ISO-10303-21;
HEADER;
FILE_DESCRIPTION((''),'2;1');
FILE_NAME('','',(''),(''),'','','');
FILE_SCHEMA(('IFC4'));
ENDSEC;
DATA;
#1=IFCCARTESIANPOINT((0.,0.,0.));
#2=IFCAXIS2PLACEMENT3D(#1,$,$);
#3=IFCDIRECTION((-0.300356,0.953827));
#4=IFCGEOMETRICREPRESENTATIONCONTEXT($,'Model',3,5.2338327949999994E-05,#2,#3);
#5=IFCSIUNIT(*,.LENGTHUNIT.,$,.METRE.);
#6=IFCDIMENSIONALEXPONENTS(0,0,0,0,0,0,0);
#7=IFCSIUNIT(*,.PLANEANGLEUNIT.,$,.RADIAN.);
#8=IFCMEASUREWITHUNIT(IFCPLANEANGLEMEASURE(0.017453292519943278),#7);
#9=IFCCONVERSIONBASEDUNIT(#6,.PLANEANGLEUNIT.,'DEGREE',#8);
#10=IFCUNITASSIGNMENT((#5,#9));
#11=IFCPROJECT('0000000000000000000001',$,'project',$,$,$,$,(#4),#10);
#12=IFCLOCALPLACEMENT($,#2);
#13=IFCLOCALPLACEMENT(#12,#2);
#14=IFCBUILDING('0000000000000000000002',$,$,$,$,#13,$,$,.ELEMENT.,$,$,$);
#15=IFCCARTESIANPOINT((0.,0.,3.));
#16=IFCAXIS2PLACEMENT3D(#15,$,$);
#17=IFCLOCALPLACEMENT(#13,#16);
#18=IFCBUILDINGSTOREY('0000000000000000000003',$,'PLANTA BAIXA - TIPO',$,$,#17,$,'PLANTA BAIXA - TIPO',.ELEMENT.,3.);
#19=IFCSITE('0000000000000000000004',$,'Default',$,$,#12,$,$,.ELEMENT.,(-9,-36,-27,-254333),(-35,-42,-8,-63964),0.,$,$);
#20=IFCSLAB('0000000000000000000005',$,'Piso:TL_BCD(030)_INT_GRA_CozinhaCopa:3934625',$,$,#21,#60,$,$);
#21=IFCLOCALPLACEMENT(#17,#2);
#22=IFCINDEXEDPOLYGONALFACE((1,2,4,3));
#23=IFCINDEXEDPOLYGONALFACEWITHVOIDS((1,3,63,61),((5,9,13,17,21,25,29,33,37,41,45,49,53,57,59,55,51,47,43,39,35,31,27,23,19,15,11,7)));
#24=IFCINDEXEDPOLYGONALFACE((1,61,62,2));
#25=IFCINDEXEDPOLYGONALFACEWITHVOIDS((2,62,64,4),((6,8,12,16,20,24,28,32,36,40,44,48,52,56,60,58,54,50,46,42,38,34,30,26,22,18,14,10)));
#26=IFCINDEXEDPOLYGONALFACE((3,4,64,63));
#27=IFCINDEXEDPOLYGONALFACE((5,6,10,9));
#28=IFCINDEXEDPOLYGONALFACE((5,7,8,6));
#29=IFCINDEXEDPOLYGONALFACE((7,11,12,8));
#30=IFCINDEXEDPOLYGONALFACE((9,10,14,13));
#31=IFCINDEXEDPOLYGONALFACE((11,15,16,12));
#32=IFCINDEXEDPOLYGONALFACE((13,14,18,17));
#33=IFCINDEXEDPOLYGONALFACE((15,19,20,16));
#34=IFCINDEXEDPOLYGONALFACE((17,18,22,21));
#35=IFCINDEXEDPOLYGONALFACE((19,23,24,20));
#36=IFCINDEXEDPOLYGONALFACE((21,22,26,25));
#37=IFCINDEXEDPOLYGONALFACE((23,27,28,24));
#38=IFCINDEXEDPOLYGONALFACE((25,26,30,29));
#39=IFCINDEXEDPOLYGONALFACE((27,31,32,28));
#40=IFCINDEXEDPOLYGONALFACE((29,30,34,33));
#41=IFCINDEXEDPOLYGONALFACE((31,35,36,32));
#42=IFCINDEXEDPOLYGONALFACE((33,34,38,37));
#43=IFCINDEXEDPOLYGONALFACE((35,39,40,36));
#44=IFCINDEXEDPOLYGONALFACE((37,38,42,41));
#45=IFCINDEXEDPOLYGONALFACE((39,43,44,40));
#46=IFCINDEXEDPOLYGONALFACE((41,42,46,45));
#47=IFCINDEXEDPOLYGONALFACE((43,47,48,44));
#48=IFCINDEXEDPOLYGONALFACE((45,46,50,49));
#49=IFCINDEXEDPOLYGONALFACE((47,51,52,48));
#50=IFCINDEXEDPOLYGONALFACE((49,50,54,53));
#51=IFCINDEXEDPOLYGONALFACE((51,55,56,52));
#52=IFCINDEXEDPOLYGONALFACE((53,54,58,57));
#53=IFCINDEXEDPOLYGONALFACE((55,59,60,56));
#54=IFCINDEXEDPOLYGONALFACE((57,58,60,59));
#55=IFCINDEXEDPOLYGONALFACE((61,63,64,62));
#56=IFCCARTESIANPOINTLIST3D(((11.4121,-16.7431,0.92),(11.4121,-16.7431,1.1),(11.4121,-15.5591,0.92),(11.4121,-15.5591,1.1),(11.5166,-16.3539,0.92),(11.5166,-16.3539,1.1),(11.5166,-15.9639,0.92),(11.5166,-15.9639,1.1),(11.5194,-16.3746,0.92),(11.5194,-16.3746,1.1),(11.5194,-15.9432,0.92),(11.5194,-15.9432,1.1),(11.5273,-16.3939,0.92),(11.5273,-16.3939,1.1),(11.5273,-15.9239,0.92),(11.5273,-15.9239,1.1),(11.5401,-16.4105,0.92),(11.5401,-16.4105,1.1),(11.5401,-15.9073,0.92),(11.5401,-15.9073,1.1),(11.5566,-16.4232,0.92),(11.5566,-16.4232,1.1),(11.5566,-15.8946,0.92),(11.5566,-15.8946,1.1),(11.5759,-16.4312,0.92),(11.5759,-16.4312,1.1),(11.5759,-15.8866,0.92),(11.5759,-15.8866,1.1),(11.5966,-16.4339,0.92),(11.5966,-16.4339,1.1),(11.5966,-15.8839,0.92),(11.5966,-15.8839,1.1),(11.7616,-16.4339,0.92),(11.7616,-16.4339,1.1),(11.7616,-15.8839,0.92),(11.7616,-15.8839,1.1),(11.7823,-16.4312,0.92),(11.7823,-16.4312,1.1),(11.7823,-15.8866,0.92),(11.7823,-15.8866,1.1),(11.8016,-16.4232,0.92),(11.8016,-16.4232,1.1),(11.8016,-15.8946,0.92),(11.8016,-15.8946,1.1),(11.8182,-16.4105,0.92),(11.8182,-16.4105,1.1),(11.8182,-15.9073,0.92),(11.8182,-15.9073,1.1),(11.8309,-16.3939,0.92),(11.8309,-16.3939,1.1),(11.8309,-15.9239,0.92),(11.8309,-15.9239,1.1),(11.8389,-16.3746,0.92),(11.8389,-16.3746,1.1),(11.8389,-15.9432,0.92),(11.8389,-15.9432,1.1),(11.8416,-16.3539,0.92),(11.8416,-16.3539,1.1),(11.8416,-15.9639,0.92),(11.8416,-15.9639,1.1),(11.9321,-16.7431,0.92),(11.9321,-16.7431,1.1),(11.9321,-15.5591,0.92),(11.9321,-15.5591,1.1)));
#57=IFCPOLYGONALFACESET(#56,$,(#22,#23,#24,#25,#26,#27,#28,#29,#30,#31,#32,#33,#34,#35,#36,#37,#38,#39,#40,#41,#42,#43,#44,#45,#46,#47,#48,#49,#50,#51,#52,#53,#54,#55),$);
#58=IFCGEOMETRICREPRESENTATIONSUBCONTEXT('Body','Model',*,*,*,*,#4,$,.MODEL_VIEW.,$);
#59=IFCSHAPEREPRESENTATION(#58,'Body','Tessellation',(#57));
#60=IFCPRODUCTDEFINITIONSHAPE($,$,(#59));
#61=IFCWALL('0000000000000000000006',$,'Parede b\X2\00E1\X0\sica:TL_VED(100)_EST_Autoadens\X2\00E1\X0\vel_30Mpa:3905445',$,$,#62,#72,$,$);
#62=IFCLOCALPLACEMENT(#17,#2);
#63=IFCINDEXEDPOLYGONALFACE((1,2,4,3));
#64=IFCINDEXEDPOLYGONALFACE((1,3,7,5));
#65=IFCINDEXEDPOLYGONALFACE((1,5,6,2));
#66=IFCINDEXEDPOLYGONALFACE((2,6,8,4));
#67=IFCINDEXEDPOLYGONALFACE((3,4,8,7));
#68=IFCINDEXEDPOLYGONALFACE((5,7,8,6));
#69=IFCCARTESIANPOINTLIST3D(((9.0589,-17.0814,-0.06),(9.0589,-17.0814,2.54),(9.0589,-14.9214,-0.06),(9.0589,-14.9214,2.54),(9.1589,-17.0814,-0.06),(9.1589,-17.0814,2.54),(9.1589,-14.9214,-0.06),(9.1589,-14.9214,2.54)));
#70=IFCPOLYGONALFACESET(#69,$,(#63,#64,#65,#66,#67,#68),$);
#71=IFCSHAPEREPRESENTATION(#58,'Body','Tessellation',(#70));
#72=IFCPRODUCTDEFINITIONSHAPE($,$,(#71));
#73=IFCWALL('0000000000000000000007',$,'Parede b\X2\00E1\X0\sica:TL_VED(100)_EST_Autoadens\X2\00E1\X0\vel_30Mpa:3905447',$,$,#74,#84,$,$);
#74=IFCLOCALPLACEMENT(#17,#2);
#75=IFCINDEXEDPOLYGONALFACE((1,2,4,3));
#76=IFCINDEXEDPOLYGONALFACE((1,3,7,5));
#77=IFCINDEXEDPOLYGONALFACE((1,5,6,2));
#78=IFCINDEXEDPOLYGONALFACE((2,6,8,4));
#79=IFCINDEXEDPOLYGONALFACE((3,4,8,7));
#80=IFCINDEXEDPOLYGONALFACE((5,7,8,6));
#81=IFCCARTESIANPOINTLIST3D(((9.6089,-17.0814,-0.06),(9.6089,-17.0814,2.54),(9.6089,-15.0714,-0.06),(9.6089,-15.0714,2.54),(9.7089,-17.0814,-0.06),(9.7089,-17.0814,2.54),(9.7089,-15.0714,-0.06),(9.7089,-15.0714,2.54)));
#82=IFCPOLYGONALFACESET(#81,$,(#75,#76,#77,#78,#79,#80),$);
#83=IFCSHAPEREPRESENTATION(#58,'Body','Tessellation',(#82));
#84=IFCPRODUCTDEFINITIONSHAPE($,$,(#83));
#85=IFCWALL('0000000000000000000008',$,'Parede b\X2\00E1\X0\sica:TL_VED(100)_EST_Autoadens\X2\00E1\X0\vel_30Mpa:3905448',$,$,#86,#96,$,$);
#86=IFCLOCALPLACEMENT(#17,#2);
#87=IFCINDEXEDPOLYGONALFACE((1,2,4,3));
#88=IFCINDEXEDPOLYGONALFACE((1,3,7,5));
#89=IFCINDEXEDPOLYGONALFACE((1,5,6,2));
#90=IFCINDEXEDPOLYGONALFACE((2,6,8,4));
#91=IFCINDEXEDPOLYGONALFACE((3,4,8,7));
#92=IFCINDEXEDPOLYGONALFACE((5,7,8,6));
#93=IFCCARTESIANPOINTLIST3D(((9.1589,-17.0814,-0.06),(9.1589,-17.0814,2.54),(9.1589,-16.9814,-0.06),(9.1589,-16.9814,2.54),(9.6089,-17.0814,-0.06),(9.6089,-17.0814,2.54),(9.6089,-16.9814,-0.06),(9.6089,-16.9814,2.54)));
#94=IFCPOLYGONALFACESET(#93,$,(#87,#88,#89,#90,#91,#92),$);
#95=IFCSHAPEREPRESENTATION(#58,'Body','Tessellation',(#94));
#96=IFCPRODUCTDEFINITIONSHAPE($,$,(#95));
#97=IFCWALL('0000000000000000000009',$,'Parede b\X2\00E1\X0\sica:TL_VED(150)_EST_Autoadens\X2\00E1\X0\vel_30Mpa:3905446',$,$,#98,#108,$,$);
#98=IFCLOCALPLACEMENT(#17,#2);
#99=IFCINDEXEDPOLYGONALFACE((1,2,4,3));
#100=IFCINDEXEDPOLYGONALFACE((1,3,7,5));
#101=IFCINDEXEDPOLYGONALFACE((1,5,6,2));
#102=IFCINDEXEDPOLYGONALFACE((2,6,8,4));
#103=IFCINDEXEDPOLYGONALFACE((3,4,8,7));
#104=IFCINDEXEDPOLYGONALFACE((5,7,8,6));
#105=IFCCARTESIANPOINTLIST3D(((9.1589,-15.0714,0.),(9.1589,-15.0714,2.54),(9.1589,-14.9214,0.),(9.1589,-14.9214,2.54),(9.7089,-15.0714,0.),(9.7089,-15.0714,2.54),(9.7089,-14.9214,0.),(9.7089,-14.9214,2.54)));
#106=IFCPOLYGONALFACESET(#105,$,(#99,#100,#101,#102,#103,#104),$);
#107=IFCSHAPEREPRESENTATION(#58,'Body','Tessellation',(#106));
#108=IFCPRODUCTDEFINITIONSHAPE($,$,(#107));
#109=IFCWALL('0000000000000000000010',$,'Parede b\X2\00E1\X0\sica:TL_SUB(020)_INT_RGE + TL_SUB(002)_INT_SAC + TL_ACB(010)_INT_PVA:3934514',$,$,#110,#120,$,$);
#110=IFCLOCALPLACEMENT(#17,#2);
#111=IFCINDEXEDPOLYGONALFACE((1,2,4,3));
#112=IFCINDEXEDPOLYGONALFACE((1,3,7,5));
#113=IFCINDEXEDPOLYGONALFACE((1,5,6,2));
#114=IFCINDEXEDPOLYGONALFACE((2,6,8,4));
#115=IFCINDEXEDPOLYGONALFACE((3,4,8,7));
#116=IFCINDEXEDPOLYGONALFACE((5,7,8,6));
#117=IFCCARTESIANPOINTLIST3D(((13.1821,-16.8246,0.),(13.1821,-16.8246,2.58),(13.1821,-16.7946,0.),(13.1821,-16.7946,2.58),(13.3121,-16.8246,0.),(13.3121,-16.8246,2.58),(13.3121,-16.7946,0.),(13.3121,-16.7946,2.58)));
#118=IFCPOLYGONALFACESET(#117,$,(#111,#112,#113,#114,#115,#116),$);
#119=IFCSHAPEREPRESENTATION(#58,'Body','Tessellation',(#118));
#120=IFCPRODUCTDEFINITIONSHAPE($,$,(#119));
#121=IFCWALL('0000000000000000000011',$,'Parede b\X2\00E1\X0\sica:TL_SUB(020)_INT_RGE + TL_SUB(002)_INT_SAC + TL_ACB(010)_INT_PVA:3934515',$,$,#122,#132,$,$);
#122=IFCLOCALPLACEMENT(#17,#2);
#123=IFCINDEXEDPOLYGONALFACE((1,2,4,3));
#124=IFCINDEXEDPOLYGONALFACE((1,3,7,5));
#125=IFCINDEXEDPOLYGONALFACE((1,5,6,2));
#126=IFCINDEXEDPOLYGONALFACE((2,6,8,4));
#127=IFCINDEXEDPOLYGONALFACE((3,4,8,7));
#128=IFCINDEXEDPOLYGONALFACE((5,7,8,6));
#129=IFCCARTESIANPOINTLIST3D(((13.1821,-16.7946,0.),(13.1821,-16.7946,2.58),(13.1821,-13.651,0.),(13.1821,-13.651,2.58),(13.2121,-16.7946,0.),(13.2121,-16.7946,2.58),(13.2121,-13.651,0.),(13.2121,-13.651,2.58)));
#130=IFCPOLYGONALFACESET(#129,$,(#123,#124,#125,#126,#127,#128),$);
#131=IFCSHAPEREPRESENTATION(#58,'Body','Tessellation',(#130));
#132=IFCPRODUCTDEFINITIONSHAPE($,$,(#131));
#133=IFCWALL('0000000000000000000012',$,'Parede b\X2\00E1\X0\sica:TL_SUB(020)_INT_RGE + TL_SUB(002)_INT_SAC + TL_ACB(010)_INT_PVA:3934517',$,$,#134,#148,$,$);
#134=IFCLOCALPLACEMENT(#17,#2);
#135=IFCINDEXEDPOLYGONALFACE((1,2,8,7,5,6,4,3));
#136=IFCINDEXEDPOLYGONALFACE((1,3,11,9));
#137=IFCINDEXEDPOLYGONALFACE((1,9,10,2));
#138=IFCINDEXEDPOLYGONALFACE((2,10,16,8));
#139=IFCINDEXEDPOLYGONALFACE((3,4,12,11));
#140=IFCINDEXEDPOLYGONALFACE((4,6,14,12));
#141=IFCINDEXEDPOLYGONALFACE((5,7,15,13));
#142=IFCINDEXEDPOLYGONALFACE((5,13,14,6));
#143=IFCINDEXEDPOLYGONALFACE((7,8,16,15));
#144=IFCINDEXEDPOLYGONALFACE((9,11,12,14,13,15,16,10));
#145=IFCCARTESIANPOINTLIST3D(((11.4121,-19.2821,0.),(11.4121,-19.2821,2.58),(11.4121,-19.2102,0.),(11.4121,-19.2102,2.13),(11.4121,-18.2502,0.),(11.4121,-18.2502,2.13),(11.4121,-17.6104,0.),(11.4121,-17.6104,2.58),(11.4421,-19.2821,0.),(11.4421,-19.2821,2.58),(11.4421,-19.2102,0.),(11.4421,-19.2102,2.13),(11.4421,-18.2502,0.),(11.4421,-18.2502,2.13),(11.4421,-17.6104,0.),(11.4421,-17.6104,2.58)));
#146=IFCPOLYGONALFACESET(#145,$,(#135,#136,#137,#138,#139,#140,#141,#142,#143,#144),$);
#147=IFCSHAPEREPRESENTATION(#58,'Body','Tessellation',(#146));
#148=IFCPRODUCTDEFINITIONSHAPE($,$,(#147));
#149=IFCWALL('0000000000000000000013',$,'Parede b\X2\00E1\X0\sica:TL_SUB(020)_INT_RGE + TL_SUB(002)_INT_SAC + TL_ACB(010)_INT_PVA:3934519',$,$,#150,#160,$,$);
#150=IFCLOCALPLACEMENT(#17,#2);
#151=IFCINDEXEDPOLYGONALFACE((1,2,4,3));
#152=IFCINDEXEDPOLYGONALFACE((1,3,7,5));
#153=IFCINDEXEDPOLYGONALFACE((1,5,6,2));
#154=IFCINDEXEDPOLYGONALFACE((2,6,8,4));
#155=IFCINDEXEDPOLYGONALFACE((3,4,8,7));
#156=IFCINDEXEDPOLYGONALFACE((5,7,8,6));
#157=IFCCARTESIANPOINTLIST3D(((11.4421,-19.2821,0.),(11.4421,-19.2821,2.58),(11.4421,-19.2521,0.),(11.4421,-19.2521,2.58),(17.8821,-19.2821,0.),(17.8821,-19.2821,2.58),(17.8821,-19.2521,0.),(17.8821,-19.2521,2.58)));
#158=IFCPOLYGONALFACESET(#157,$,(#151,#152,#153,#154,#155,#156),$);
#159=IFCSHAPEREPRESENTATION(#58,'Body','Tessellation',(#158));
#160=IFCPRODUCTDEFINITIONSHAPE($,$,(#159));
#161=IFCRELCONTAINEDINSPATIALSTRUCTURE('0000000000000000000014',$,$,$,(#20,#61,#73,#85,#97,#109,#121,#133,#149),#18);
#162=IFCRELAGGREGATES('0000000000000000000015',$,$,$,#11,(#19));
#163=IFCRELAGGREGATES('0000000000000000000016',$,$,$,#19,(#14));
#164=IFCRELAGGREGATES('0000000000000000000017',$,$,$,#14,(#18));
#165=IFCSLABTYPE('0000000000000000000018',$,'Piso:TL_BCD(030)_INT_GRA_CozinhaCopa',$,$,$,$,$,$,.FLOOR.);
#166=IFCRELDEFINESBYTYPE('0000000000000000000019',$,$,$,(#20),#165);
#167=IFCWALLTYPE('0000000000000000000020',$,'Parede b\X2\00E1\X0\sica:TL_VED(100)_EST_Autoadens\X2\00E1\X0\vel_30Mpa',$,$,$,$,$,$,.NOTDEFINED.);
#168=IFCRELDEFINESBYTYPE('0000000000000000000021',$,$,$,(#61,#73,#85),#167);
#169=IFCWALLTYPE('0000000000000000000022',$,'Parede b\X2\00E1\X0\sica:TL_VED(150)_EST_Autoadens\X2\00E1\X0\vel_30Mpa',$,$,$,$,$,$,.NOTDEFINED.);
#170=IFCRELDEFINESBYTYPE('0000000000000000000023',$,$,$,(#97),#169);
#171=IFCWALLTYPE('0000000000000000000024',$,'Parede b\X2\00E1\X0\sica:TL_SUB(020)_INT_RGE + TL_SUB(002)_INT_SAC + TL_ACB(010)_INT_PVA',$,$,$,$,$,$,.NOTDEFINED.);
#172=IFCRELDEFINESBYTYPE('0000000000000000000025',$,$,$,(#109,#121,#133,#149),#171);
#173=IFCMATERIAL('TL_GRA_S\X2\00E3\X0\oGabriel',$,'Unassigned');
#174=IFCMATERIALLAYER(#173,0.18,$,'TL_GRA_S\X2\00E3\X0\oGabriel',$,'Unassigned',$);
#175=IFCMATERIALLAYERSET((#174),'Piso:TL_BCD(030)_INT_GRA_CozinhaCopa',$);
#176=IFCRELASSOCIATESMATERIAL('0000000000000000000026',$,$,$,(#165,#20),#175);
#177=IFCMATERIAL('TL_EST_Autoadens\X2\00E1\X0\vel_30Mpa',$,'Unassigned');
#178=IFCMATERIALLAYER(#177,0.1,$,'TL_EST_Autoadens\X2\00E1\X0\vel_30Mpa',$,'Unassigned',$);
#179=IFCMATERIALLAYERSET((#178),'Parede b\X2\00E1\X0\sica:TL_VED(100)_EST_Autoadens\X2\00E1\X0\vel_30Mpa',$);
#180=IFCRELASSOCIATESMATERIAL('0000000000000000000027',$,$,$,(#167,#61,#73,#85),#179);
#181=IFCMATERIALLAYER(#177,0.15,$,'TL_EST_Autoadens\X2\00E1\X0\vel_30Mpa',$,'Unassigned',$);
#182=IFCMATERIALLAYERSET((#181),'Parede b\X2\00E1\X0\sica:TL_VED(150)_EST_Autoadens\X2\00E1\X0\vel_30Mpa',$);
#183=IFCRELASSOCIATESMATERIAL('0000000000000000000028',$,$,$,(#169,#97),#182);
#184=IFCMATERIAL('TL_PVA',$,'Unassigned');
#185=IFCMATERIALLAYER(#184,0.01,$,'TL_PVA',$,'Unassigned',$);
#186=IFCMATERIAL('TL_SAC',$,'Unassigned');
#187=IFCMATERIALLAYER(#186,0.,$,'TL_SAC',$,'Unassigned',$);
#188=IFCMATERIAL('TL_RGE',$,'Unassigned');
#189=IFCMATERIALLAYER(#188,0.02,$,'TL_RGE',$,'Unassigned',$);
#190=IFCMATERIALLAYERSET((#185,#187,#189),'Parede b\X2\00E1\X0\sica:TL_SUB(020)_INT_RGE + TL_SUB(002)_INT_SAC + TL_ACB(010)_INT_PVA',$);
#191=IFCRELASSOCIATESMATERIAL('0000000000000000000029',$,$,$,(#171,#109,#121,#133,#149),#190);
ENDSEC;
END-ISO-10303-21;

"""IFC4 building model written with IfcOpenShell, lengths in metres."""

from ifc_helpers import new_model, entity, si_unit, converted_unit, direction, frame, frame_2d, origin, place, context, subcontext, project, spatial, polyline, circle_curve, parameter, trimmed, segment, composite_curve, rectangle, outline, extrude, material, layer, layer_set, layer_usage, type_object, element, save


model = new_model("IFC4")

# Units and contexts
model_context = context("Model", 3, precision=5.2338327949999994e-05, world=origin(), true_north=direction((-0.300356, 0.953827)))
body_context = subcontext(model_context, "Body", "Model", "MODEL_VIEW")
ifc_project = project(units=[si_unit("LENGTHUNIT", "METRE"), converted_unit("PLANEANGLEUNIT", "DEGREE", entity("IfcPlaneAngleMeasure", 0.017453292519943278), si_unit("PLANEANGLEUNIT", "RADIAN"), dimensions=[0, 0, 0, 0, 0, 0, 0])], contexts=[model_context])

# Site, building, storey
site_placement = place(None, origin())
site = spatial("IfcSite", under=ifc_project, at=site_placement, Name="Default", CompositionType="ELEMENT", RefLatitude=(-9, -36, -27, -254333), RefLongitude=(-35, -42, -8, -63964), RefElevation=0.0)
building_placement = place(site_placement, origin())
building = spatial("IfcBuilding", under=site, at=building_placement, CompositionType="ELEMENT")
storey_placement = place(building_placement, frame((0.0, 0.0, 3.0)))
storey = spatial("IfcBuildingStorey", under=building, at=storey_placement, Name="PLANTA BAIXA - TIPO", LongName="PLANTA BAIXA - TIPO", CompositionType="ELEMENT", Elevation=3.0)

# Slab, opening
ifc_material_1 = material(Name="TL_GRA_SãoGabriel", Category="Unassigned")
ifc_layer_1 = layer(ifc_material_1, 0.18, Name="TL_GRA_SãoGabriel", Category="Unassigned")
ifc_layer_set_1 = layer_set([ifc_layer_1], Name="Piso:TL_BCD(030)_INT_GRA_CozinhaCopa")
ifc_layer_usage_1 = layer_usage(ifc_layer_set_1, "AXIS3", "POSITIVE", 0.0)
slab_type_1 = type_object("IfcSlabType", Name="Piso:TL_BCD(030)_INT_GRA_CozinhaCopa", PredefinedType="FLOOR", material=ifc_layer_set_1)
slab_1_placement = place(storey_placement, frame((11.4121, -16.7431, 0.92)))
slab_1 = element("IfcSlab", 1, at=slab_1_placement, inside=storey, type_object=slab_type_1, material=ifc_layer_usage_1, Name="Piso:TL_BCD(030)_INT_GRA_CozinhaCopa:3934625", context=body_context, shape_type="SweptSolid", body=[
    extrude(rectangle(XDim=0.52, YDim=1.184, at=frame_2d((0.0, 0.0), x_axis=(-1.0, 0.0))), frame((0.26, 0.592, 0.18), z_axis=(0.0, 0.0, -1.0), x_axis=(-1.0, 0.0, 0.0)), (0.0, 0.0, 1.0), 0.18),
])
opening_1_placement = place(slab_1_placement, frame((-11.4121, 16.7431, 0.18)))
element("IfcOpeningElement", 2, at=opening_1_placement, cuts=slab_1, PredefinedType="OPENING", context=body_context, shape_type="SweptSolid", body=[
    extrude(outline(composite_curve([segment(trimmed(circle_curve(frame_2d((0.195, -0.0825), x_axis=(1.0, 0.0)), 0.08), [parameter(270.0)], [parameter(0.0)], True, "PARAMETER"), True, "CONTINUOUS"), segment(polyline([(0.275, -0.0825), (0.275, 0.0825)]), True, "CONTINUOUS"), segment(trimmed(circle_curve(frame_2d((0.195, 0.0825), x_axis=(1.0, 0.0)), 0.08), [parameter(0.0)], [parameter(90.0)], True, "PARAMETER"), True, "CONTINUOUS"), segment(polyline([(0.195, 0.1625), (-0.195, 0.1625)]), True, "CONTINUOUS"), segment(trimmed(circle_curve(frame_2d((-0.195, 0.0825), x_axis=(1.0, 0.0)), 0.08), [parameter(90.0)], [parameter(180.0)], True, "PARAMETER"), True, "CONTINUOUS"), segment(polyline([(-0.275, 0.0825), (-0.275, -0.0825)]), True, "CONTINUOUS"), segment(trimmed(circle_curve(frame_2d((-0.195, -0.0825), x_axis=(1.0, 0.0)), 0.08), [parameter(180.0)], [parameter(270.0)], True, "PARAMETER"), True, "CONTINUOUS"), segment(polyline([(-0.195, -0.1625), (0.195, -0.1625)]), True, "CONTINUOUS")], self_intersect=False)), frame((11.6791, -16.1589, -0.21), z_axis=(0.0, 0.0, 1.0), x_axis=(0.0, -1.0, 0.0)), (0.0, 0.0, 1.0), 0.21),
])

# Walls
ifc_material_2 = material(Name="TL_EST_Autoadensável_30Mpa", Category="Unassigned")
ifc_layer_2 = layer(ifc_material_2, 0.1, Name="TL_EST_Autoadensável_30Mpa", Category="Unassigned")
ifc_layer_set_2 = layer_set([ifc_layer_2], Name="Parede básica:TL_VED(100)_EST_Autoadensável_30Mpa")
ifc_layer_usage_2 = layer_usage(ifc_layer_set_2, "AXIS2", "NEGATIVE", 0.05)
wall_type_1 = type_object("IfcWallType", Name="Parede básica:TL_VED(100)_EST_Autoadensável_30Mpa", PredefinedType="NOTDEFINED", material=ifc_layer_set_2)
wall_1_placement = place(storey_placement, frame((9.1089, -17.0814, -0.06), z_axis=(0.0, 0.0, 1.0), x_axis=(0.0, 1.0, 0.0)))
element("IfcWall", 3, at=wall_1_placement, inside=storey, type_object=wall_type_1, material=ifc_layer_usage_2, Name="Parede básica:TL_VED(100)_EST_Autoadensável_30Mpa:3905445", context=body_context, shape_type="SweptSolid", body=[
    extrude(rectangle(XDim=2.16, YDim=0.1, at=frame_2d((1.08, 0.0), x_axis=(-1.0, 0.0))), origin(), (0.0, 0.0, 1.0), 2.6),
])
ifc_layer_usage_3 = layer_usage(ifc_layer_set_2, "AXIS2", "NEGATIVE", 0.05)
wall_2_placement = place(storey_placement, frame((9.6589, -15.0714, -0.06), z_axis=(0.0, 0.0, 1.0), x_axis=(0.0, -1.0, 0.0)))
element("IfcWall", 4, at=wall_2_placement, inside=storey, type_object=wall_type_1, material=ifc_layer_usage_3, Name="Parede básica:TL_VED(100)_EST_Autoadensável_30Mpa:3905447", context=body_context, shape_type="SweptSolid", body=[
    extrude(rectangle(XDim=2.01, YDim=0.1, at=frame_2d((1.005, 0.0), x_axis=(-1.0, 0.0))), origin(), (0.0, 0.0, 1.0), 2.6),
])
ifc_layer_usage_4 = layer_usage(ifc_layer_set_2, "AXIS2", "NEGATIVE", 0.05)
wall_3_placement = place(storey_placement, frame((9.6089, -17.0314, -0.06), z_axis=(0.0, 0.0, 1.0), x_axis=(-1.0, 0.0, 0.0)))
element("IfcWall", 5, at=wall_3_placement, inside=storey, type_object=wall_type_1, material=ifc_layer_usage_4, Name="Parede básica:TL_VED(100)_EST_Autoadensável_30Mpa:3905448", context=body_context, shape_type="SweptSolid", body=[
    extrude(rectangle(XDim=0.45, YDim=0.1, at=frame_2d((0.225, 0.0), x_axis=(-1.0, 0.0))), origin(), (0.0, 0.0, 1.0), 2.6),
])
ifc_layer_3 = layer(ifc_material_2, 0.15, Name="TL_EST_Autoadensável_30Mpa", Category="Unassigned")
ifc_layer_set_3 = layer_set([ifc_layer_3], Name="Parede básica:TL_VED(150)_EST_Autoadensável_30Mpa")
ifc_layer_usage_5 = layer_usage(ifc_layer_set_3, "AXIS2", "NEGATIVE", 0.075)
wall_type_2 = type_object("IfcWallType", Name="Parede básica:TL_VED(150)_EST_Autoadensável_30Mpa", PredefinedType="NOTDEFINED", material=ifc_layer_set_3)
wall_4_placement = place(storey_placement, frame((9.1589, -14.9964, 0.0)))
element("IfcWall", 6, at=wall_4_placement, inside=storey, type_object=wall_type_2, material=ifc_layer_usage_5, Name="Parede básica:TL_VED(150)_EST_Autoadensável_30Mpa:3905446", context=body_context, shape_type="SweptSolid", body=[
    extrude(rectangle(XDim=0.55, YDim=0.15, at=frame_2d((0.275, 0.0), x_axis=(-1.0, 0.0))), origin(), (0.0, 0.0, 1.0), 2.54),
])
ifc_material_3 = material(Name="TL_PVA", Category="Unassigned")
ifc_layer_4 = layer(ifc_material_3, 0.01, Name="TL_PVA", Category="Unassigned")
ifc_material_4 = material(Name="TL_SAC", Category="Unassigned")
ifc_layer_5 = layer(ifc_material_4, 0.0, Name="TL_SAC", Category="Unassigned")
ifc_material_5 = material(Name="TL_RGE", Category="Unassigned")
ifc_layer_6 = layer(ifc_material_5, 0.02, Name="TL_RGE", Category="Unassigned")
ifc_layer_set_4 = layer_set([ifc_layer_4, ifc_layer_5, ifc_layer_6], Name="Parede básica:TL_SUB(020)_INT_RGE + TL_SUB(002)_INT_SAC + TL_ACB(010)_INT_PVA")
ifc_layer_usage_6 = layer_usage(ifc_layer_set_4, "AXIS2", "POSITIVE", -0.015)
wall_type_3 = type_object("IfcWallType", Name="Parede básica:TL_SUB(020)_INT_RGE + TL_SUB(002)_INT_SAC + TL_ACB(010)_INT_PVA", PredefinedType="NOTDEFINED", material=ifc_layer_set_4)
wall_5_placement = place(storey_placement, frame((13.1821, -16.8096, 0.0)))
element("IfcWall", 7, at=wall_5_placement, inside=storey, type_object=wall_type_3, material=ifc_layer_usage_6, Name="Parede básica:TL_SUB(020)_INT_RGE + TL_SUB(002)_INT_SAC + TL_ACB(010)_INT_PVA:3934514", context=body_context, shape_type="SweptSolid", body=[
    extrude(rectangle(XDim=0.13, YDim=0.03, at=frame_2d((0.065, 0.0), x_axis=(-1.0, 0.0))), origin(), (0.0, 0.0, 1.0), 2.58),
])
ifc_layer_usage_7 = layer_usage(ifc_layer_set_4, "AXIS2", "POSITIVE", -0.015)
wall_6_placement = place(storey_placement, frame((13.1971, -13.651, 0.0), z_axis=(0.0, 0.0, 1.0), x_axis=(0.0, -1.0, 0.0)))
element("IfcWall", 8, at=wall_6_placement, inside=storey, type_object=wall_type_3, material=ifc_layer_usage_7, Name="Parede básica:TL_SUB(020)_INT_RGE + TL_SUB(002)_INT_SAC + TL_ACB(010)_INT_PVA:3934515", context=body_context, shape_type="SweptSolid", body=[
    extrude(rectangle(XDim=3.1437, YDim=0.03, at=frame_2d((1.5718, 0.0), x_axis=(-1.0, 0.0))), origin(), (0.0, 0.0, 1.0), 2.58),
])

# Wall, opening
ifc_layer_usage_8 = layer_usage(ifc_layer_set_4, "AXIS2", "POSITIVE", -0.015)
wall_7_placement = place(storey_placement, frame((11.4271, -19.2821, 0.0), z_axis=(0.0, 0.0, 1.0), x_axis=(0.0, 1.0, 0.0)))
wall_7 = element("IfcWall", 9, at=wall_7_placement, inside=storey, type_object=wall_type_3, material=ifc_layer_usage_8, Name="Parede básica:TL_SUB(020)_INT_RGE + TL_SUB(002)_INT_SAC + TL_ACB(010)_INT_PVA:3934517", context=body_context, shape_type="SweptSolid", body=[
    extrude(rectangle(XDim=1.6717, YDim=0.03, at=frame_2d((0.8359, 0.0), x_axis=(-1.0, 0.0))), origin(), (0.0, 0.0, 1.0), 2.58),
])
opening_2_placement = place(wall_7_placement, frame((19.2821, 11.4271, 0.0)))
element("IfcOpeningElement", 10, at=opening_2_placement, cuts=wall_7, PredefinedType="OPENING", context=body_context, shape_type="SweptSolid", body=[
    extrude(rectangle(XDim=2.13, YDim=0.96, at=frame_2d((0.0, 0.0), x_axis=(0.0, 1.0))), frame((-18.7302, -12.9361, 1.065), z_axis=(0.0, 1.0, 0.0), x_axis=(-1.0, 0.0, 0.0)), (0.0, 0.0, 1.0), 3.048),
])

# Wall
ifc_layer_usage_9 = layer_usage(ifc_layer_set_4, "AXIS2", "NEGATIVE", 0.015)
wall_8_placement = place(storey_placement, frame((11.4421, -19.2671, 0.0)))
element("IfcWall", 11, at=wall_8_placement, inside=storey, type_object=wall_type_3, material=ifc_layer_usage_9, Name="Parede básica:TL_SUB(020)_INT_RGE + TL_SUB(002)_INT_SAC + TL_ACB(010)_INT_PVA:3934519", context=body_context, shape_type="SweptSolid", body=[
    extrude(rectangle(XDim=6.44, YDim=0.03, at=frame_2d((3.22, 0.0), x_axis=(-1.0, 0.0))), origin(), (0.0, 0.0, 1.0), 2.58),
])

save(model, "model.ifc")
